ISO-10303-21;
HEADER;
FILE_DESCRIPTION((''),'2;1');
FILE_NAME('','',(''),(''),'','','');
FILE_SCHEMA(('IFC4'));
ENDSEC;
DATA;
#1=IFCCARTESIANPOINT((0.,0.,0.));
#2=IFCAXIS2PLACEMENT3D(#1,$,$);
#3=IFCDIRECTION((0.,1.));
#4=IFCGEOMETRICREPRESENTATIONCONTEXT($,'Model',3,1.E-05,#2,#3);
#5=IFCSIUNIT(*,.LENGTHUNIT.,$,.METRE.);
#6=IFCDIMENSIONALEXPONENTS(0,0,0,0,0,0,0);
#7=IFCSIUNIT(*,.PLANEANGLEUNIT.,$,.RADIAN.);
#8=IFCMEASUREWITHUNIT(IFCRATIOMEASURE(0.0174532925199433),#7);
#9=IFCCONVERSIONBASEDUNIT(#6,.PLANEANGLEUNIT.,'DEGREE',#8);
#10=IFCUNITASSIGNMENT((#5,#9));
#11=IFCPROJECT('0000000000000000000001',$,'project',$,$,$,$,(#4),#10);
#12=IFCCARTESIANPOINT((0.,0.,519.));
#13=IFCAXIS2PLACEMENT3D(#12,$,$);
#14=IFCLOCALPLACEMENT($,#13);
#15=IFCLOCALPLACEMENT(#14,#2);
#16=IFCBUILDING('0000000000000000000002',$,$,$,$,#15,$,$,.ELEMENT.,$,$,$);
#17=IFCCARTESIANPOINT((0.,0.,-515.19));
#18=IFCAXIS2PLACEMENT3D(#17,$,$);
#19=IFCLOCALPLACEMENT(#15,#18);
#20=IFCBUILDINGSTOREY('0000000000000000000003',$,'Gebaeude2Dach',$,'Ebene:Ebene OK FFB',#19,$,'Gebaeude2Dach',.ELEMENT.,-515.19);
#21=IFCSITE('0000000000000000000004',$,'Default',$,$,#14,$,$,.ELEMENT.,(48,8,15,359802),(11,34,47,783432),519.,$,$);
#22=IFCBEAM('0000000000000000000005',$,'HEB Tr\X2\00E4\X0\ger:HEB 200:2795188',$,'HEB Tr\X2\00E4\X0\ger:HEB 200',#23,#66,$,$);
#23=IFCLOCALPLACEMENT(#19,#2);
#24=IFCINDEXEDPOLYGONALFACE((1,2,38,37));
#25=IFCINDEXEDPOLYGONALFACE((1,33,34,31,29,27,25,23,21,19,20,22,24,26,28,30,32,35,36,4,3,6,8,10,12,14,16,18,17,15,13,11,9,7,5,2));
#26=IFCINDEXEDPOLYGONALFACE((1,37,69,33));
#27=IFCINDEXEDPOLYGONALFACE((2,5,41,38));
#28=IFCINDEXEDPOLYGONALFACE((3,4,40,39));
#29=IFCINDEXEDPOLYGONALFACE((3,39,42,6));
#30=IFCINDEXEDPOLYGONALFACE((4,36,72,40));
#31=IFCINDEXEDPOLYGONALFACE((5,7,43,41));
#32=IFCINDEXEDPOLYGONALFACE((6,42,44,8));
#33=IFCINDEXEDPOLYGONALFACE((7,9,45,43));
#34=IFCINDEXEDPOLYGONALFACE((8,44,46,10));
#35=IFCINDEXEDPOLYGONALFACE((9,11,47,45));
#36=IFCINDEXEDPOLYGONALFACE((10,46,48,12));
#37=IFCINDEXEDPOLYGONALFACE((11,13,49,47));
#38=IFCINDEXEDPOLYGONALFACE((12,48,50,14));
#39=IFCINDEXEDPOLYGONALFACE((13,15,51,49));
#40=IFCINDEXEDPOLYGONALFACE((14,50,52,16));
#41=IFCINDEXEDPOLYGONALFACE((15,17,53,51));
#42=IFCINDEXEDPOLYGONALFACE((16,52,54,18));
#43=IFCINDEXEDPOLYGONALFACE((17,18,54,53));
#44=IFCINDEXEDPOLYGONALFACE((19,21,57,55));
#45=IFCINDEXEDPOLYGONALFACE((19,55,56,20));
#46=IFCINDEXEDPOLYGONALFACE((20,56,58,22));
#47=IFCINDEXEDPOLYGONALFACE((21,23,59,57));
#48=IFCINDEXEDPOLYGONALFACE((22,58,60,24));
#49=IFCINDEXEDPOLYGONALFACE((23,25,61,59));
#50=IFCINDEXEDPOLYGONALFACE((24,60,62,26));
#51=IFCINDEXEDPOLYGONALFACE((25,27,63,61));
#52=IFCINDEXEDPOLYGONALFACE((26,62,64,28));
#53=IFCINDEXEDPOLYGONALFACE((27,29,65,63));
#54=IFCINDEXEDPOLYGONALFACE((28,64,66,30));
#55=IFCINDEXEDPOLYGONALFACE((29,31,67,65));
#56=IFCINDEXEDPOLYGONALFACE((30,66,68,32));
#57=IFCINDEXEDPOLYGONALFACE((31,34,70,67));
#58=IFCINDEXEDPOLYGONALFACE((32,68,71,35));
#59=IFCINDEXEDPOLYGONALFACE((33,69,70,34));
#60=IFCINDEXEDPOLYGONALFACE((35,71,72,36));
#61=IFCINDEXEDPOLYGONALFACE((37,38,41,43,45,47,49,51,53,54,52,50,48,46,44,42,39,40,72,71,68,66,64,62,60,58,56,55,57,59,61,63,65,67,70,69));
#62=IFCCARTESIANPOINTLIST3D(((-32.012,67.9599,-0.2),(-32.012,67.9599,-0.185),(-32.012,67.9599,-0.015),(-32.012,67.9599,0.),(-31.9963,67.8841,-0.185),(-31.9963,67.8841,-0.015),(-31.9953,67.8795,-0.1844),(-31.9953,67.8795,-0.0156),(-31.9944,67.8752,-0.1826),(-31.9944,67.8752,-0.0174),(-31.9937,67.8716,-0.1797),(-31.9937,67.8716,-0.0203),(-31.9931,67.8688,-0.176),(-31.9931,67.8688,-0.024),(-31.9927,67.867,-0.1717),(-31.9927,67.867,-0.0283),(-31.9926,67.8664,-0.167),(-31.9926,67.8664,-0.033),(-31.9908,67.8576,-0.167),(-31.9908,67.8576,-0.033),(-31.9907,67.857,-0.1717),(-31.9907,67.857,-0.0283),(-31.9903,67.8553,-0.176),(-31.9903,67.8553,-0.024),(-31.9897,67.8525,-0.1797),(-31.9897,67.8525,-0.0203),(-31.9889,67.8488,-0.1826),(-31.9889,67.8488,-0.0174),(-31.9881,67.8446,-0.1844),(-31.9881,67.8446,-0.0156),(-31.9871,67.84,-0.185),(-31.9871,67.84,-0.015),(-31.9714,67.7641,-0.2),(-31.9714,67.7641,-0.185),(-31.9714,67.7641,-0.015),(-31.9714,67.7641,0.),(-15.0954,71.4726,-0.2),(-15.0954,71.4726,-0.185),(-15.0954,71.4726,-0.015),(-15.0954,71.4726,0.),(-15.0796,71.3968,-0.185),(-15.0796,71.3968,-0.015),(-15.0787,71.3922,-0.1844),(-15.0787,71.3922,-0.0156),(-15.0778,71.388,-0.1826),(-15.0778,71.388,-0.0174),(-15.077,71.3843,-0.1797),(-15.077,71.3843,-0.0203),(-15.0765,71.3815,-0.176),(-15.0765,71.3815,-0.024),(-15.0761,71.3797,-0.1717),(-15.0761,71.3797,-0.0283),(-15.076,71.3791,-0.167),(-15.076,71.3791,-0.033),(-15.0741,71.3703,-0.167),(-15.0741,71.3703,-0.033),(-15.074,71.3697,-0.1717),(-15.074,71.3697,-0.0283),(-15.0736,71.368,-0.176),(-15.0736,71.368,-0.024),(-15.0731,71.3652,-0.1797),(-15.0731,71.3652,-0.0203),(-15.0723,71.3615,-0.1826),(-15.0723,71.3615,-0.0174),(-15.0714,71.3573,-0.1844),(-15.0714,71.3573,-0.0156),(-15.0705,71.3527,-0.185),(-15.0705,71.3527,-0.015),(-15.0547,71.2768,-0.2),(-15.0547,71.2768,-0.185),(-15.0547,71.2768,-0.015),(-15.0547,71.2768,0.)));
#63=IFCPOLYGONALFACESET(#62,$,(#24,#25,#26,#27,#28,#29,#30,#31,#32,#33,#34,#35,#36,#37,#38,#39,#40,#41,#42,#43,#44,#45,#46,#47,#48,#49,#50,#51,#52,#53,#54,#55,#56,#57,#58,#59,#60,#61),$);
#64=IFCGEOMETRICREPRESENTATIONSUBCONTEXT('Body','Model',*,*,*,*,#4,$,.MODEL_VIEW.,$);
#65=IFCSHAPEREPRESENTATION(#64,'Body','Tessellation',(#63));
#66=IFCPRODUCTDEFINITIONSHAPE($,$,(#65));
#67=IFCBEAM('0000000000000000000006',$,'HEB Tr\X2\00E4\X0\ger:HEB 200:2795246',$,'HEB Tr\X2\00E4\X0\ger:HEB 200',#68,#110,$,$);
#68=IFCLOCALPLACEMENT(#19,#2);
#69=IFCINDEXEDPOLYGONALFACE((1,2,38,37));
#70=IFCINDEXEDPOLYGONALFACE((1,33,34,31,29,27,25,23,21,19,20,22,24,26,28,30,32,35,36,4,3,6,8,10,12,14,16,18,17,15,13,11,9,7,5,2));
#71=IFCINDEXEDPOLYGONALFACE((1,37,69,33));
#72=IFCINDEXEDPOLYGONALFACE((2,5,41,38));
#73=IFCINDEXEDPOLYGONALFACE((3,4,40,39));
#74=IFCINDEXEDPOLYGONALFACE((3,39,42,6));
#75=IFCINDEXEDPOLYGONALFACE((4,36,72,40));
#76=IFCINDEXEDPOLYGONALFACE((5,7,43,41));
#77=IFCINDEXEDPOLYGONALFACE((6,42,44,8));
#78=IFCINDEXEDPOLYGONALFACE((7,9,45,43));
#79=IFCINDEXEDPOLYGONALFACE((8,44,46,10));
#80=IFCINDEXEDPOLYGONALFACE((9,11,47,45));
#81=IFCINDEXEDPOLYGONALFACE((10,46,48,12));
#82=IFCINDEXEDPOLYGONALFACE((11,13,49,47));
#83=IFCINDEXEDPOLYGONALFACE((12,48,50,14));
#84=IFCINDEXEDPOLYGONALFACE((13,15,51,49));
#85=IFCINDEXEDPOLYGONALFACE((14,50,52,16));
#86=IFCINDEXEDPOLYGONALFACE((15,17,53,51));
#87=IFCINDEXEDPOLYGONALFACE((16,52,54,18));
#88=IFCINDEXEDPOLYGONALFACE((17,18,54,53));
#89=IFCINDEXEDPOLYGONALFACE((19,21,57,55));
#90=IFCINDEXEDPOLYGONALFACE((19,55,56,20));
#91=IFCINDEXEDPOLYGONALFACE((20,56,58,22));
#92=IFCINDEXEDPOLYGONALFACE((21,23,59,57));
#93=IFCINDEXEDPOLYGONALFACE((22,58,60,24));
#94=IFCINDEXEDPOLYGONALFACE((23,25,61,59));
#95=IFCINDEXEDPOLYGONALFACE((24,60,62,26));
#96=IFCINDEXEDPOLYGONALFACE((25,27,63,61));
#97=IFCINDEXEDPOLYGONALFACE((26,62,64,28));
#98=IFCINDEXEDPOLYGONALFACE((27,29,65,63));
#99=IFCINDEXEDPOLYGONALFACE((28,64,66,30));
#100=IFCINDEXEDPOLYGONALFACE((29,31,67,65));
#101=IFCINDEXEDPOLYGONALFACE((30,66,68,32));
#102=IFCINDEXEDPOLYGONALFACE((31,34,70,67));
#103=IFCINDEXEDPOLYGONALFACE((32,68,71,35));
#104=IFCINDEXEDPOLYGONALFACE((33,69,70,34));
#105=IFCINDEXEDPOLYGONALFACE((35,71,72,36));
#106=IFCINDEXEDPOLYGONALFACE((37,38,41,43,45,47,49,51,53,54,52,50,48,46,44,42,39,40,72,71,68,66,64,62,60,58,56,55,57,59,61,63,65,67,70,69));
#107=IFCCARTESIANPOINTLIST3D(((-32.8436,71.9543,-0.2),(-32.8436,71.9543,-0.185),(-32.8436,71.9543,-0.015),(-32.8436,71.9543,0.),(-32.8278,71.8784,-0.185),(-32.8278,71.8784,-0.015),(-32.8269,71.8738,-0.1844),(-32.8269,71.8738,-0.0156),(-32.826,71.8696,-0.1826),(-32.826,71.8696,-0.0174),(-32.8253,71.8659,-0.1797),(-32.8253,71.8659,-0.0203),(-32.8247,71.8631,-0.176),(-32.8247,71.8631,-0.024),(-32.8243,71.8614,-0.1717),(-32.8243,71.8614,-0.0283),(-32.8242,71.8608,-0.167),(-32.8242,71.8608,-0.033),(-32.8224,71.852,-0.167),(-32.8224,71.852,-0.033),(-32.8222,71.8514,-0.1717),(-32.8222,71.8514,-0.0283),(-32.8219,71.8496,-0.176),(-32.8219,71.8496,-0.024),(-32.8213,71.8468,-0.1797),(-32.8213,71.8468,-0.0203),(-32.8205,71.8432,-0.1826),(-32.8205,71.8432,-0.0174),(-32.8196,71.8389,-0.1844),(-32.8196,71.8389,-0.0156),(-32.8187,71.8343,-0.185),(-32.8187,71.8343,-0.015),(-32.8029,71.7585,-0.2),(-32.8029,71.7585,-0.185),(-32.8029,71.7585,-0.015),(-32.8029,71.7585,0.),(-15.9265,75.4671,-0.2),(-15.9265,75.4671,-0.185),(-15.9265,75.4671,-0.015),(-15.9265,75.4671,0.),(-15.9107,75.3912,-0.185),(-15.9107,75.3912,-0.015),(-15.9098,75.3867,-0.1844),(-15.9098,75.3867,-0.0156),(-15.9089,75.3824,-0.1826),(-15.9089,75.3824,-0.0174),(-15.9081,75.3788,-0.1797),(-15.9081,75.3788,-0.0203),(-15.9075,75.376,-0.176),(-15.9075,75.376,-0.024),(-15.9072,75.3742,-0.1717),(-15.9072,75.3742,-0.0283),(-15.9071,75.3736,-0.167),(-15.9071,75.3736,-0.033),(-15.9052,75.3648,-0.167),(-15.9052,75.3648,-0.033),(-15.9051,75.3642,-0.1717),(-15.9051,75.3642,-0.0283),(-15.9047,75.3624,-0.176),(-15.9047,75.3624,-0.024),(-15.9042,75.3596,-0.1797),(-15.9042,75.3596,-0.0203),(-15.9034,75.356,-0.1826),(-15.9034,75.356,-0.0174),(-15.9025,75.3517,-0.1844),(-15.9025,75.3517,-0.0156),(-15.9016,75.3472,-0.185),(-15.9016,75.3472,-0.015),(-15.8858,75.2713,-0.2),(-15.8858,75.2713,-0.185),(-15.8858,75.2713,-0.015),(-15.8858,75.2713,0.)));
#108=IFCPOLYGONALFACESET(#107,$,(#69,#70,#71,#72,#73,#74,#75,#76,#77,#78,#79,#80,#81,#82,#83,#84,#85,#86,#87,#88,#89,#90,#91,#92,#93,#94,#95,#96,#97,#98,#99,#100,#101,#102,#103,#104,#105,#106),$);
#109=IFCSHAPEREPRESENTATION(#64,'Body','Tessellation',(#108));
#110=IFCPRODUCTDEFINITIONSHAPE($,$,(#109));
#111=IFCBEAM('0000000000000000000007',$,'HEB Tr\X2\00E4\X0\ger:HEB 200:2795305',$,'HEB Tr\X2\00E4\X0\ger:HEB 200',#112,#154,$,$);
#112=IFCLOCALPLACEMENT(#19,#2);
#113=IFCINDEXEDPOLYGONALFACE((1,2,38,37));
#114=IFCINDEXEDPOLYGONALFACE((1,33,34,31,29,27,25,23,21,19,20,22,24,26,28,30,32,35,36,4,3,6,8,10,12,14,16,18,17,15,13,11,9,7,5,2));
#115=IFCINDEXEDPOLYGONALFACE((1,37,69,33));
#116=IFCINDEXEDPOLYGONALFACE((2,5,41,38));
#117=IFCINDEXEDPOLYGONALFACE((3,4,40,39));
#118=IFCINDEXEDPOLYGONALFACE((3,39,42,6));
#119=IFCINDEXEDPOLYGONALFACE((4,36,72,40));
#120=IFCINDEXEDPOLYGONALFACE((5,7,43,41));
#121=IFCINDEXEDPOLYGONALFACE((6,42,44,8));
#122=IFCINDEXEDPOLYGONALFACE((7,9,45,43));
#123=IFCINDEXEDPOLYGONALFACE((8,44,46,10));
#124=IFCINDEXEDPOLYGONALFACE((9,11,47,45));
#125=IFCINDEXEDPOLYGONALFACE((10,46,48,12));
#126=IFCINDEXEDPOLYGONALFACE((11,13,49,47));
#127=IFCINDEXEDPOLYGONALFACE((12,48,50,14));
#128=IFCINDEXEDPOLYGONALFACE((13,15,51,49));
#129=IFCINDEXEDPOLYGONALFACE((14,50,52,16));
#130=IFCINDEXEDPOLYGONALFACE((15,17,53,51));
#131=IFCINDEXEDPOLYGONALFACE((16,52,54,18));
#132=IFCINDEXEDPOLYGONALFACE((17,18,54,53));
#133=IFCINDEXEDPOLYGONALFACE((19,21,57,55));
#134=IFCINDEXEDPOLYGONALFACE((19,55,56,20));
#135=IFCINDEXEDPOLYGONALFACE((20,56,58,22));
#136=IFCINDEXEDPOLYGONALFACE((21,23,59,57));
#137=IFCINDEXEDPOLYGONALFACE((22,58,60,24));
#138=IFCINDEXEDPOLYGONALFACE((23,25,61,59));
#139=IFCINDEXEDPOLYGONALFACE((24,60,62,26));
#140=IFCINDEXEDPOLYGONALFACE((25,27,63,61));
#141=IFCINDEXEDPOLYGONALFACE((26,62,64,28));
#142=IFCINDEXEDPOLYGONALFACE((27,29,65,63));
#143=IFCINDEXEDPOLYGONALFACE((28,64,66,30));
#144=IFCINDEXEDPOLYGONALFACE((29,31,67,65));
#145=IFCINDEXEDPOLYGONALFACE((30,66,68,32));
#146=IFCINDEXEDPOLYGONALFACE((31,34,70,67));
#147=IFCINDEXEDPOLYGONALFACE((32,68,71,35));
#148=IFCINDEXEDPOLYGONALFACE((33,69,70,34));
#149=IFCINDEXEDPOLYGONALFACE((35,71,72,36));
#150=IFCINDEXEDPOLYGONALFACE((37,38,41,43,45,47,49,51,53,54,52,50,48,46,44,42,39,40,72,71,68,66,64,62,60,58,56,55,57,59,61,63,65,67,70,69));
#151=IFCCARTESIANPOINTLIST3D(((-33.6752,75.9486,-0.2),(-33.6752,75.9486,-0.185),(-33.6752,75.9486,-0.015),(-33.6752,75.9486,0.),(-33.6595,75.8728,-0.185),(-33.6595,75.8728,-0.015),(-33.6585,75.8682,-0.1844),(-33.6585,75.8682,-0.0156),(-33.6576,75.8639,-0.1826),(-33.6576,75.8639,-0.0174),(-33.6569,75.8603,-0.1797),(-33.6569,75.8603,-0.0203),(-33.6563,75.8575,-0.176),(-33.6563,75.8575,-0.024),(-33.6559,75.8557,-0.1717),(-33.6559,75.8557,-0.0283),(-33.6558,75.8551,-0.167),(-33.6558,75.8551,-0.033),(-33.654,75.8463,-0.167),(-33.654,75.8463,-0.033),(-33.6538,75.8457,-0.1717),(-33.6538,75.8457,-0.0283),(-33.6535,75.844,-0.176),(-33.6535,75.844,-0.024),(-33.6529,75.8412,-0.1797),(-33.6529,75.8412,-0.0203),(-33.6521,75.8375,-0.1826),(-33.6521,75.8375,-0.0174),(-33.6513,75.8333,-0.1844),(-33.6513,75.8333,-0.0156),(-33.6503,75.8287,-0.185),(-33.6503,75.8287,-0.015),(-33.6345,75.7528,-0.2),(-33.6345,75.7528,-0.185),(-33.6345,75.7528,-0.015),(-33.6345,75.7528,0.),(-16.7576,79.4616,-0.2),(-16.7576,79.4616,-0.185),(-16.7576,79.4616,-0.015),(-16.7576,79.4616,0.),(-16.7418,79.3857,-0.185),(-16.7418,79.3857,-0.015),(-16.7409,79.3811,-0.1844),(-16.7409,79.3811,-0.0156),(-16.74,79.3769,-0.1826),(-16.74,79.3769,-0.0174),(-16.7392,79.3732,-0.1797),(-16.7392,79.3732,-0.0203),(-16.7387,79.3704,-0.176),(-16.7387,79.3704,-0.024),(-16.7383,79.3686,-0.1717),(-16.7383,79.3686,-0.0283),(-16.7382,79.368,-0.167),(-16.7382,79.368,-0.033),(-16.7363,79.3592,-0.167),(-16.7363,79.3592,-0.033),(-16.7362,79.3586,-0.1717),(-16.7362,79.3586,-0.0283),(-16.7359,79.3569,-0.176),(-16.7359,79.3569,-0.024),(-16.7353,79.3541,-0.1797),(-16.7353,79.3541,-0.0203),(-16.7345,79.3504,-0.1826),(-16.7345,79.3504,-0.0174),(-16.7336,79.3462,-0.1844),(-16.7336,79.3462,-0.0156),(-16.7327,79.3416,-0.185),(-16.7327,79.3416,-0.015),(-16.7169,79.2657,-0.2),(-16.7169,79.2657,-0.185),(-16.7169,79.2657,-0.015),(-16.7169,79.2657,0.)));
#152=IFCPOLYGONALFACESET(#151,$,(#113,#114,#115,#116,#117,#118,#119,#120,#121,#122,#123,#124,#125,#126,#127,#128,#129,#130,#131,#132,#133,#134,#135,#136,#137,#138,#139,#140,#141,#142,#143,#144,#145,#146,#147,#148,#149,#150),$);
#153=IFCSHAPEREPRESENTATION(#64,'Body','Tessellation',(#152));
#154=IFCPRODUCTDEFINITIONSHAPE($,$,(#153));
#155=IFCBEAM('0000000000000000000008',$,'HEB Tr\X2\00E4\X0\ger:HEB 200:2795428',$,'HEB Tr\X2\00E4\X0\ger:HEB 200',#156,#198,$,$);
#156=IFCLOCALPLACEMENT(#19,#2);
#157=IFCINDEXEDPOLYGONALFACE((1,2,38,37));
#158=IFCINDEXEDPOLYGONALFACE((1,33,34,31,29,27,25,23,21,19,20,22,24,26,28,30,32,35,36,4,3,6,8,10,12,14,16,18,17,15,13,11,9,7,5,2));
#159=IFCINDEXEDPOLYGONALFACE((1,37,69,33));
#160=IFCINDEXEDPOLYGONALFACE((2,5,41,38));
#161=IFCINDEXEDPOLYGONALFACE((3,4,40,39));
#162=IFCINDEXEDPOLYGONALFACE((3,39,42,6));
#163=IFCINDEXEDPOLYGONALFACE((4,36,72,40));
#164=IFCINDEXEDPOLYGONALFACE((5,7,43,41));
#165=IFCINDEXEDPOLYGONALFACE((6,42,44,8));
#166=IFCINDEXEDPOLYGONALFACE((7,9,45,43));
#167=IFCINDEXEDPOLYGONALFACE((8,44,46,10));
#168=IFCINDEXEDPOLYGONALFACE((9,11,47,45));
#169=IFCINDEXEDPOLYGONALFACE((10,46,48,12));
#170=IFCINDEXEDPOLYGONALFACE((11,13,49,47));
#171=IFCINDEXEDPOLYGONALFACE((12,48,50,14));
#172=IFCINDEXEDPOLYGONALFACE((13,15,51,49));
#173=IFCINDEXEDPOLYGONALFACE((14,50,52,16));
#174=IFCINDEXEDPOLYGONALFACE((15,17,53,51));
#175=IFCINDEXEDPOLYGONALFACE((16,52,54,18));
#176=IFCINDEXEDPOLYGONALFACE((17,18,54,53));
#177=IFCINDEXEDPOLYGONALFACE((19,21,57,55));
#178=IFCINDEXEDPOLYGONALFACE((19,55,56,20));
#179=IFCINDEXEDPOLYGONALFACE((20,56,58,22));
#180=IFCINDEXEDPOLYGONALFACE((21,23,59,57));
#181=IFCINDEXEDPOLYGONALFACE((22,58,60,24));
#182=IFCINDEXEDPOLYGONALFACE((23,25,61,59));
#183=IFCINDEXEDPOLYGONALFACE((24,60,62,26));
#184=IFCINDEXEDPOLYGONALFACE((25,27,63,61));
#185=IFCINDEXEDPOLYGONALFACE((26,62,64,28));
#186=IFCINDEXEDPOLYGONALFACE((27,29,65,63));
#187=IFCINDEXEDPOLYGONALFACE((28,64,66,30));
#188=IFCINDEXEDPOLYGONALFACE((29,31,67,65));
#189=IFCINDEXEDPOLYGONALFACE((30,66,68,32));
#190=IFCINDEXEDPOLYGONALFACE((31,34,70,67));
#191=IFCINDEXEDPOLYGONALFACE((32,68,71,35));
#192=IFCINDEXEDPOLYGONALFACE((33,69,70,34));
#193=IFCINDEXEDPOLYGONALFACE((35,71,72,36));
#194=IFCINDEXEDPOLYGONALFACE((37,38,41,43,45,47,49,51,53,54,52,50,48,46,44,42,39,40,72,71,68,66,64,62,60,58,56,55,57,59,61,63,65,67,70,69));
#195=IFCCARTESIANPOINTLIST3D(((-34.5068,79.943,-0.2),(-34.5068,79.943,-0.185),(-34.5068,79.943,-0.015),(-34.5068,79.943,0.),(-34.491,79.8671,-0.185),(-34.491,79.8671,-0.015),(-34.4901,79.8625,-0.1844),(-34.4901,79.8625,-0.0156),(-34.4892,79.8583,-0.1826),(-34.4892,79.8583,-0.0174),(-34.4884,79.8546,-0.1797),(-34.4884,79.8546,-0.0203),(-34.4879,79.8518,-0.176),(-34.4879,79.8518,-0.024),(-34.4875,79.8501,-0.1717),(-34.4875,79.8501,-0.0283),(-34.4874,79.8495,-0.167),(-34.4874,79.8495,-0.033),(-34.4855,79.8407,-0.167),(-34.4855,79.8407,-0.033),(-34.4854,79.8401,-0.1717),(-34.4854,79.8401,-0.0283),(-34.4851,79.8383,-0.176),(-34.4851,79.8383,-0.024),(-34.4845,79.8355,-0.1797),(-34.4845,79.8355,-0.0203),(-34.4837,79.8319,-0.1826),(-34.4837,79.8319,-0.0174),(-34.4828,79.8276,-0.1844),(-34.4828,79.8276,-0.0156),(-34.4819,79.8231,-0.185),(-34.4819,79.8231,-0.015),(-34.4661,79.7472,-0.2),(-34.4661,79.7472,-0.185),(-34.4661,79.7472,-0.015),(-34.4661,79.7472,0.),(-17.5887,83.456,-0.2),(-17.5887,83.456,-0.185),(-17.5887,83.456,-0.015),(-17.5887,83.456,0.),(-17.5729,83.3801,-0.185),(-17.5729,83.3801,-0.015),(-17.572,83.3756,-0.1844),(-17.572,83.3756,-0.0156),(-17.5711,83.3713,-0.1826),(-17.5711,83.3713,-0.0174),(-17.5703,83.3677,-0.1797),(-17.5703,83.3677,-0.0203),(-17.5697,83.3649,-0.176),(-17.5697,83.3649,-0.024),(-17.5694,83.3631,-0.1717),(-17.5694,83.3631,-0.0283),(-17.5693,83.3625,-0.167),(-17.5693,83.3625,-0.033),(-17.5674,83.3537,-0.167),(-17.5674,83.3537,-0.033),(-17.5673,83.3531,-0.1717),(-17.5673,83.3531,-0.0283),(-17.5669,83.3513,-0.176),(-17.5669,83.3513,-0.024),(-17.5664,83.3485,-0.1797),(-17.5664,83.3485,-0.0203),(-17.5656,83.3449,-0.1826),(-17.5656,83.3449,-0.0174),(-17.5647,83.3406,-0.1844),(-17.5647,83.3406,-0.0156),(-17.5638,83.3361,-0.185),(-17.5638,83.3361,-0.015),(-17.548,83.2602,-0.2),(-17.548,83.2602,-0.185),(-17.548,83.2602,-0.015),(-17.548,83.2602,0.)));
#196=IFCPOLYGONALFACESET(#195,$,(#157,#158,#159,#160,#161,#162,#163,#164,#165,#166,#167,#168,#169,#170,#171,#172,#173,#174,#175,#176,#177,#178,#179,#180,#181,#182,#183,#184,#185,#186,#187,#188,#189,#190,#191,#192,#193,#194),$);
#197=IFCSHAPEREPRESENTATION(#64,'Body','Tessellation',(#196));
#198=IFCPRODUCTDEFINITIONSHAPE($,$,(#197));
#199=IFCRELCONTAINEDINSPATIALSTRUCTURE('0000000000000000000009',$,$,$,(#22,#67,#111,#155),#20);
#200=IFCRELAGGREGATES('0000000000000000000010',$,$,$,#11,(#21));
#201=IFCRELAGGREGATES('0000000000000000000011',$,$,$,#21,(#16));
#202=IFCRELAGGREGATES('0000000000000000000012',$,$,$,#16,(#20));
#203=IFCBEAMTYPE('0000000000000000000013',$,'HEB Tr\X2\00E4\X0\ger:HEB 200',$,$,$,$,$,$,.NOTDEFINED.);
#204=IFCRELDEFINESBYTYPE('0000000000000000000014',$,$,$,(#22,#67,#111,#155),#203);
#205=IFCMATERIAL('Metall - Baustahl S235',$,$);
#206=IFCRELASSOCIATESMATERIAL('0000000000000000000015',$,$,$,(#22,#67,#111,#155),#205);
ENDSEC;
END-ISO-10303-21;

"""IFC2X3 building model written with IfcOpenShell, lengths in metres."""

from ifc_helpers import new_model, entity, si_unit, converted_unit, direction, frame, frame_2d, origin, place, context, subcontext, project, spatial, i_section, extrude, material, type_object, element, save


model = new_model("IFC2X3")

# Units and contexts
model_context = context("Model", 3, precision=1e-05, world=origin(), true_north=direction((0.0, 1.0)))
body_context = subcontext(model_context, "Body", "Model", "MODEL_VIEW")
ifc_project = project(units=[si_unit("LENGTHUNIT", "METRE"), converted_unit("PLANEANGLEUNIT", "DEGREE", entity("IfcRatioMeasure", 0.0174532925199433), si_unit("PLANEANGLEUNIT", "RADIAN"), dimensions=[0, 0, 0, 0, 0, 0, 0])], contexts=[model_context])

# Site, building, storey
site_placement = place(None, frame((0.0, 0.0, 519.0)))
site = spatial("IfcSite", under=ifc_project, at=site_placement, Name="Default", CompositionType="ELEMENT", RefLatitude=(48, 8, 15, 359802), RefLongitude=(11, 34, 47, 783432), RefElevation=519.0)
building_placement = place(site_placement, origin())
building = spatial("IfcBuilding", under=site, at=building_placement, CompositionType="ELEMENT")
storey_placement = place(building_placement, frame((0.0, 0.0, -515.19)))
storey = spatial("IfcBuildingStorey", under=building, at=storey_placement, Name="Gebaeude2Dach", ObjectType="Ebene:Ebene OK FFB", LongName="Gebaeude2Dach", CompositionType="ELEMENT", Elevation=-515.19)

# Beams
ifc_material = material(Name="Metall - Baustahl S235")
beam_type = type_object("IfcBeamType", Name="HEB Träger:HEB 200", PredefinedType="NOTDEFINED")
beam_1_placement = place(storey_placement, frame((-14.9617, 71.3983, 0.0), z_axis=(0.0, 0.0, 1.0), x_axis=(-0.979114, -0.203311, 0.0)))
element("IfcBeam", 1, at=beam_1_placement, inside=storey, type_object=beam_type, material=ifc_material, Name="HEB Träger:HEB 200:2795188", ObjectType="HEB Träger:HEB 200", context=body_context, shape_type="SweptSolid", body=[
    extrude(i_section(OverallWidth=0.2, OverallDepth=0.2, WebThickness=0.009, FlangeThickness=0.015, FilletRadius=0.018, at=frame_2d((0.0, 0.0), x_axis=(0.0, 1.0))), frame((0.1158, 0.0, -0.1), z_axis=(1.0, 0.0, 0.0), x_axis=(0.0, 0.0, -1.0)), (0.0, 0.0, 1.0), 17.2775),
])
beam_2_placement = place(storey_placement, frame((-15.7928, 75.3927, 0.0), z_axis=(0.0, 0.0, 1.0), x_axis=(-0.979114, -0.203311, 0.0)))
element("IfcBeam", 2, at=beam_2_placement, inside=storey, type_object=beam_type, material=ifc_material, Name="HEB Träger:HEB 200:2795246", ObjectType="HEB Träger:HEB 200", context=body_context, shape_type="SweptSolid", body=[
    extrude(i_section(OverallWidth=0.2, OverallDepth=0.2, WebThickness=0.009, FlangeThickness=0.015, FilletRadius=0.018, at=frame_2d((0.0, 0.0), x_axis=(0.0, 1.0))), frame((0.1158, 0.0, -0.1), z_axis=(1.0, 0.0, 0.0), x_axis=(0.0, 0.0, -1.0)), (0.0, 0.0, 1.0), 17.278),
])
beam_3_placement = place(storey_placement, frame((-16.6239, 79.3872, 0.0), z_axis=(0.0, 0.0, 1.0), x_axis=(-0.979114, -0.203311, 0.0)))
element("IfcBeam", 3, at=beam_3_placement, inside=storey, type_object=beam_type, material=ifc_material, Name="HEB Träger:HEB 200:2795305", ObjectType="HEB Träger:HEB 200", context=body_context, shape_type="SweptSolid", body=[
    extrude(i_section(OverallWidth=0.2, OverallDepth=0.2, WebThickness=0.009, FlangeThickness=0.015, FilletRadius=0.018, at=frame_2d((0.0, 0.0), x_axis=(0.0, 1.0))), frame((0.1158, 0.0, -0.1), z_axis=(1.0, 0.0, 0.0), x_axis=(0.0, 0.0, -1.0)), (0.0, 0.0, 1.0), 17.2785),
])
beam_4_placement = place(storey_placement, frame((-17.455, 83.3816, 0.0), z_axis=(0.0, 0.0, 1.0), x_axis=(-0.979114, -0.203311, 0.0)))
element("IfcBeam", 4, at=beam_4_placement, inside=storey, type_object=beam_type, material=ifc_material, Name="HEB Träger:HEB 200:2795428", ObjectType="HEB Träger:HEB 200", context=body_context, shape_type="SweptSolid", body=[
    extrude(i_section(OverallWidth=0.2, OverallDepth=0.2, WebThickness=0.009, FlangeThickness=0.015, FilletRadius=0.018, at=frame_2d((0.0, 0.0), x_axis=(0.0, 1.0))), frame((0.1158, 0.0, -0.1), z_axis=(1.0, 0.0, 0.0), x_axis=(0.0, 0.0, -1.0)), (0.0, 0.0, 1.0), 17.279),
])

save(model, "model.ifc")
